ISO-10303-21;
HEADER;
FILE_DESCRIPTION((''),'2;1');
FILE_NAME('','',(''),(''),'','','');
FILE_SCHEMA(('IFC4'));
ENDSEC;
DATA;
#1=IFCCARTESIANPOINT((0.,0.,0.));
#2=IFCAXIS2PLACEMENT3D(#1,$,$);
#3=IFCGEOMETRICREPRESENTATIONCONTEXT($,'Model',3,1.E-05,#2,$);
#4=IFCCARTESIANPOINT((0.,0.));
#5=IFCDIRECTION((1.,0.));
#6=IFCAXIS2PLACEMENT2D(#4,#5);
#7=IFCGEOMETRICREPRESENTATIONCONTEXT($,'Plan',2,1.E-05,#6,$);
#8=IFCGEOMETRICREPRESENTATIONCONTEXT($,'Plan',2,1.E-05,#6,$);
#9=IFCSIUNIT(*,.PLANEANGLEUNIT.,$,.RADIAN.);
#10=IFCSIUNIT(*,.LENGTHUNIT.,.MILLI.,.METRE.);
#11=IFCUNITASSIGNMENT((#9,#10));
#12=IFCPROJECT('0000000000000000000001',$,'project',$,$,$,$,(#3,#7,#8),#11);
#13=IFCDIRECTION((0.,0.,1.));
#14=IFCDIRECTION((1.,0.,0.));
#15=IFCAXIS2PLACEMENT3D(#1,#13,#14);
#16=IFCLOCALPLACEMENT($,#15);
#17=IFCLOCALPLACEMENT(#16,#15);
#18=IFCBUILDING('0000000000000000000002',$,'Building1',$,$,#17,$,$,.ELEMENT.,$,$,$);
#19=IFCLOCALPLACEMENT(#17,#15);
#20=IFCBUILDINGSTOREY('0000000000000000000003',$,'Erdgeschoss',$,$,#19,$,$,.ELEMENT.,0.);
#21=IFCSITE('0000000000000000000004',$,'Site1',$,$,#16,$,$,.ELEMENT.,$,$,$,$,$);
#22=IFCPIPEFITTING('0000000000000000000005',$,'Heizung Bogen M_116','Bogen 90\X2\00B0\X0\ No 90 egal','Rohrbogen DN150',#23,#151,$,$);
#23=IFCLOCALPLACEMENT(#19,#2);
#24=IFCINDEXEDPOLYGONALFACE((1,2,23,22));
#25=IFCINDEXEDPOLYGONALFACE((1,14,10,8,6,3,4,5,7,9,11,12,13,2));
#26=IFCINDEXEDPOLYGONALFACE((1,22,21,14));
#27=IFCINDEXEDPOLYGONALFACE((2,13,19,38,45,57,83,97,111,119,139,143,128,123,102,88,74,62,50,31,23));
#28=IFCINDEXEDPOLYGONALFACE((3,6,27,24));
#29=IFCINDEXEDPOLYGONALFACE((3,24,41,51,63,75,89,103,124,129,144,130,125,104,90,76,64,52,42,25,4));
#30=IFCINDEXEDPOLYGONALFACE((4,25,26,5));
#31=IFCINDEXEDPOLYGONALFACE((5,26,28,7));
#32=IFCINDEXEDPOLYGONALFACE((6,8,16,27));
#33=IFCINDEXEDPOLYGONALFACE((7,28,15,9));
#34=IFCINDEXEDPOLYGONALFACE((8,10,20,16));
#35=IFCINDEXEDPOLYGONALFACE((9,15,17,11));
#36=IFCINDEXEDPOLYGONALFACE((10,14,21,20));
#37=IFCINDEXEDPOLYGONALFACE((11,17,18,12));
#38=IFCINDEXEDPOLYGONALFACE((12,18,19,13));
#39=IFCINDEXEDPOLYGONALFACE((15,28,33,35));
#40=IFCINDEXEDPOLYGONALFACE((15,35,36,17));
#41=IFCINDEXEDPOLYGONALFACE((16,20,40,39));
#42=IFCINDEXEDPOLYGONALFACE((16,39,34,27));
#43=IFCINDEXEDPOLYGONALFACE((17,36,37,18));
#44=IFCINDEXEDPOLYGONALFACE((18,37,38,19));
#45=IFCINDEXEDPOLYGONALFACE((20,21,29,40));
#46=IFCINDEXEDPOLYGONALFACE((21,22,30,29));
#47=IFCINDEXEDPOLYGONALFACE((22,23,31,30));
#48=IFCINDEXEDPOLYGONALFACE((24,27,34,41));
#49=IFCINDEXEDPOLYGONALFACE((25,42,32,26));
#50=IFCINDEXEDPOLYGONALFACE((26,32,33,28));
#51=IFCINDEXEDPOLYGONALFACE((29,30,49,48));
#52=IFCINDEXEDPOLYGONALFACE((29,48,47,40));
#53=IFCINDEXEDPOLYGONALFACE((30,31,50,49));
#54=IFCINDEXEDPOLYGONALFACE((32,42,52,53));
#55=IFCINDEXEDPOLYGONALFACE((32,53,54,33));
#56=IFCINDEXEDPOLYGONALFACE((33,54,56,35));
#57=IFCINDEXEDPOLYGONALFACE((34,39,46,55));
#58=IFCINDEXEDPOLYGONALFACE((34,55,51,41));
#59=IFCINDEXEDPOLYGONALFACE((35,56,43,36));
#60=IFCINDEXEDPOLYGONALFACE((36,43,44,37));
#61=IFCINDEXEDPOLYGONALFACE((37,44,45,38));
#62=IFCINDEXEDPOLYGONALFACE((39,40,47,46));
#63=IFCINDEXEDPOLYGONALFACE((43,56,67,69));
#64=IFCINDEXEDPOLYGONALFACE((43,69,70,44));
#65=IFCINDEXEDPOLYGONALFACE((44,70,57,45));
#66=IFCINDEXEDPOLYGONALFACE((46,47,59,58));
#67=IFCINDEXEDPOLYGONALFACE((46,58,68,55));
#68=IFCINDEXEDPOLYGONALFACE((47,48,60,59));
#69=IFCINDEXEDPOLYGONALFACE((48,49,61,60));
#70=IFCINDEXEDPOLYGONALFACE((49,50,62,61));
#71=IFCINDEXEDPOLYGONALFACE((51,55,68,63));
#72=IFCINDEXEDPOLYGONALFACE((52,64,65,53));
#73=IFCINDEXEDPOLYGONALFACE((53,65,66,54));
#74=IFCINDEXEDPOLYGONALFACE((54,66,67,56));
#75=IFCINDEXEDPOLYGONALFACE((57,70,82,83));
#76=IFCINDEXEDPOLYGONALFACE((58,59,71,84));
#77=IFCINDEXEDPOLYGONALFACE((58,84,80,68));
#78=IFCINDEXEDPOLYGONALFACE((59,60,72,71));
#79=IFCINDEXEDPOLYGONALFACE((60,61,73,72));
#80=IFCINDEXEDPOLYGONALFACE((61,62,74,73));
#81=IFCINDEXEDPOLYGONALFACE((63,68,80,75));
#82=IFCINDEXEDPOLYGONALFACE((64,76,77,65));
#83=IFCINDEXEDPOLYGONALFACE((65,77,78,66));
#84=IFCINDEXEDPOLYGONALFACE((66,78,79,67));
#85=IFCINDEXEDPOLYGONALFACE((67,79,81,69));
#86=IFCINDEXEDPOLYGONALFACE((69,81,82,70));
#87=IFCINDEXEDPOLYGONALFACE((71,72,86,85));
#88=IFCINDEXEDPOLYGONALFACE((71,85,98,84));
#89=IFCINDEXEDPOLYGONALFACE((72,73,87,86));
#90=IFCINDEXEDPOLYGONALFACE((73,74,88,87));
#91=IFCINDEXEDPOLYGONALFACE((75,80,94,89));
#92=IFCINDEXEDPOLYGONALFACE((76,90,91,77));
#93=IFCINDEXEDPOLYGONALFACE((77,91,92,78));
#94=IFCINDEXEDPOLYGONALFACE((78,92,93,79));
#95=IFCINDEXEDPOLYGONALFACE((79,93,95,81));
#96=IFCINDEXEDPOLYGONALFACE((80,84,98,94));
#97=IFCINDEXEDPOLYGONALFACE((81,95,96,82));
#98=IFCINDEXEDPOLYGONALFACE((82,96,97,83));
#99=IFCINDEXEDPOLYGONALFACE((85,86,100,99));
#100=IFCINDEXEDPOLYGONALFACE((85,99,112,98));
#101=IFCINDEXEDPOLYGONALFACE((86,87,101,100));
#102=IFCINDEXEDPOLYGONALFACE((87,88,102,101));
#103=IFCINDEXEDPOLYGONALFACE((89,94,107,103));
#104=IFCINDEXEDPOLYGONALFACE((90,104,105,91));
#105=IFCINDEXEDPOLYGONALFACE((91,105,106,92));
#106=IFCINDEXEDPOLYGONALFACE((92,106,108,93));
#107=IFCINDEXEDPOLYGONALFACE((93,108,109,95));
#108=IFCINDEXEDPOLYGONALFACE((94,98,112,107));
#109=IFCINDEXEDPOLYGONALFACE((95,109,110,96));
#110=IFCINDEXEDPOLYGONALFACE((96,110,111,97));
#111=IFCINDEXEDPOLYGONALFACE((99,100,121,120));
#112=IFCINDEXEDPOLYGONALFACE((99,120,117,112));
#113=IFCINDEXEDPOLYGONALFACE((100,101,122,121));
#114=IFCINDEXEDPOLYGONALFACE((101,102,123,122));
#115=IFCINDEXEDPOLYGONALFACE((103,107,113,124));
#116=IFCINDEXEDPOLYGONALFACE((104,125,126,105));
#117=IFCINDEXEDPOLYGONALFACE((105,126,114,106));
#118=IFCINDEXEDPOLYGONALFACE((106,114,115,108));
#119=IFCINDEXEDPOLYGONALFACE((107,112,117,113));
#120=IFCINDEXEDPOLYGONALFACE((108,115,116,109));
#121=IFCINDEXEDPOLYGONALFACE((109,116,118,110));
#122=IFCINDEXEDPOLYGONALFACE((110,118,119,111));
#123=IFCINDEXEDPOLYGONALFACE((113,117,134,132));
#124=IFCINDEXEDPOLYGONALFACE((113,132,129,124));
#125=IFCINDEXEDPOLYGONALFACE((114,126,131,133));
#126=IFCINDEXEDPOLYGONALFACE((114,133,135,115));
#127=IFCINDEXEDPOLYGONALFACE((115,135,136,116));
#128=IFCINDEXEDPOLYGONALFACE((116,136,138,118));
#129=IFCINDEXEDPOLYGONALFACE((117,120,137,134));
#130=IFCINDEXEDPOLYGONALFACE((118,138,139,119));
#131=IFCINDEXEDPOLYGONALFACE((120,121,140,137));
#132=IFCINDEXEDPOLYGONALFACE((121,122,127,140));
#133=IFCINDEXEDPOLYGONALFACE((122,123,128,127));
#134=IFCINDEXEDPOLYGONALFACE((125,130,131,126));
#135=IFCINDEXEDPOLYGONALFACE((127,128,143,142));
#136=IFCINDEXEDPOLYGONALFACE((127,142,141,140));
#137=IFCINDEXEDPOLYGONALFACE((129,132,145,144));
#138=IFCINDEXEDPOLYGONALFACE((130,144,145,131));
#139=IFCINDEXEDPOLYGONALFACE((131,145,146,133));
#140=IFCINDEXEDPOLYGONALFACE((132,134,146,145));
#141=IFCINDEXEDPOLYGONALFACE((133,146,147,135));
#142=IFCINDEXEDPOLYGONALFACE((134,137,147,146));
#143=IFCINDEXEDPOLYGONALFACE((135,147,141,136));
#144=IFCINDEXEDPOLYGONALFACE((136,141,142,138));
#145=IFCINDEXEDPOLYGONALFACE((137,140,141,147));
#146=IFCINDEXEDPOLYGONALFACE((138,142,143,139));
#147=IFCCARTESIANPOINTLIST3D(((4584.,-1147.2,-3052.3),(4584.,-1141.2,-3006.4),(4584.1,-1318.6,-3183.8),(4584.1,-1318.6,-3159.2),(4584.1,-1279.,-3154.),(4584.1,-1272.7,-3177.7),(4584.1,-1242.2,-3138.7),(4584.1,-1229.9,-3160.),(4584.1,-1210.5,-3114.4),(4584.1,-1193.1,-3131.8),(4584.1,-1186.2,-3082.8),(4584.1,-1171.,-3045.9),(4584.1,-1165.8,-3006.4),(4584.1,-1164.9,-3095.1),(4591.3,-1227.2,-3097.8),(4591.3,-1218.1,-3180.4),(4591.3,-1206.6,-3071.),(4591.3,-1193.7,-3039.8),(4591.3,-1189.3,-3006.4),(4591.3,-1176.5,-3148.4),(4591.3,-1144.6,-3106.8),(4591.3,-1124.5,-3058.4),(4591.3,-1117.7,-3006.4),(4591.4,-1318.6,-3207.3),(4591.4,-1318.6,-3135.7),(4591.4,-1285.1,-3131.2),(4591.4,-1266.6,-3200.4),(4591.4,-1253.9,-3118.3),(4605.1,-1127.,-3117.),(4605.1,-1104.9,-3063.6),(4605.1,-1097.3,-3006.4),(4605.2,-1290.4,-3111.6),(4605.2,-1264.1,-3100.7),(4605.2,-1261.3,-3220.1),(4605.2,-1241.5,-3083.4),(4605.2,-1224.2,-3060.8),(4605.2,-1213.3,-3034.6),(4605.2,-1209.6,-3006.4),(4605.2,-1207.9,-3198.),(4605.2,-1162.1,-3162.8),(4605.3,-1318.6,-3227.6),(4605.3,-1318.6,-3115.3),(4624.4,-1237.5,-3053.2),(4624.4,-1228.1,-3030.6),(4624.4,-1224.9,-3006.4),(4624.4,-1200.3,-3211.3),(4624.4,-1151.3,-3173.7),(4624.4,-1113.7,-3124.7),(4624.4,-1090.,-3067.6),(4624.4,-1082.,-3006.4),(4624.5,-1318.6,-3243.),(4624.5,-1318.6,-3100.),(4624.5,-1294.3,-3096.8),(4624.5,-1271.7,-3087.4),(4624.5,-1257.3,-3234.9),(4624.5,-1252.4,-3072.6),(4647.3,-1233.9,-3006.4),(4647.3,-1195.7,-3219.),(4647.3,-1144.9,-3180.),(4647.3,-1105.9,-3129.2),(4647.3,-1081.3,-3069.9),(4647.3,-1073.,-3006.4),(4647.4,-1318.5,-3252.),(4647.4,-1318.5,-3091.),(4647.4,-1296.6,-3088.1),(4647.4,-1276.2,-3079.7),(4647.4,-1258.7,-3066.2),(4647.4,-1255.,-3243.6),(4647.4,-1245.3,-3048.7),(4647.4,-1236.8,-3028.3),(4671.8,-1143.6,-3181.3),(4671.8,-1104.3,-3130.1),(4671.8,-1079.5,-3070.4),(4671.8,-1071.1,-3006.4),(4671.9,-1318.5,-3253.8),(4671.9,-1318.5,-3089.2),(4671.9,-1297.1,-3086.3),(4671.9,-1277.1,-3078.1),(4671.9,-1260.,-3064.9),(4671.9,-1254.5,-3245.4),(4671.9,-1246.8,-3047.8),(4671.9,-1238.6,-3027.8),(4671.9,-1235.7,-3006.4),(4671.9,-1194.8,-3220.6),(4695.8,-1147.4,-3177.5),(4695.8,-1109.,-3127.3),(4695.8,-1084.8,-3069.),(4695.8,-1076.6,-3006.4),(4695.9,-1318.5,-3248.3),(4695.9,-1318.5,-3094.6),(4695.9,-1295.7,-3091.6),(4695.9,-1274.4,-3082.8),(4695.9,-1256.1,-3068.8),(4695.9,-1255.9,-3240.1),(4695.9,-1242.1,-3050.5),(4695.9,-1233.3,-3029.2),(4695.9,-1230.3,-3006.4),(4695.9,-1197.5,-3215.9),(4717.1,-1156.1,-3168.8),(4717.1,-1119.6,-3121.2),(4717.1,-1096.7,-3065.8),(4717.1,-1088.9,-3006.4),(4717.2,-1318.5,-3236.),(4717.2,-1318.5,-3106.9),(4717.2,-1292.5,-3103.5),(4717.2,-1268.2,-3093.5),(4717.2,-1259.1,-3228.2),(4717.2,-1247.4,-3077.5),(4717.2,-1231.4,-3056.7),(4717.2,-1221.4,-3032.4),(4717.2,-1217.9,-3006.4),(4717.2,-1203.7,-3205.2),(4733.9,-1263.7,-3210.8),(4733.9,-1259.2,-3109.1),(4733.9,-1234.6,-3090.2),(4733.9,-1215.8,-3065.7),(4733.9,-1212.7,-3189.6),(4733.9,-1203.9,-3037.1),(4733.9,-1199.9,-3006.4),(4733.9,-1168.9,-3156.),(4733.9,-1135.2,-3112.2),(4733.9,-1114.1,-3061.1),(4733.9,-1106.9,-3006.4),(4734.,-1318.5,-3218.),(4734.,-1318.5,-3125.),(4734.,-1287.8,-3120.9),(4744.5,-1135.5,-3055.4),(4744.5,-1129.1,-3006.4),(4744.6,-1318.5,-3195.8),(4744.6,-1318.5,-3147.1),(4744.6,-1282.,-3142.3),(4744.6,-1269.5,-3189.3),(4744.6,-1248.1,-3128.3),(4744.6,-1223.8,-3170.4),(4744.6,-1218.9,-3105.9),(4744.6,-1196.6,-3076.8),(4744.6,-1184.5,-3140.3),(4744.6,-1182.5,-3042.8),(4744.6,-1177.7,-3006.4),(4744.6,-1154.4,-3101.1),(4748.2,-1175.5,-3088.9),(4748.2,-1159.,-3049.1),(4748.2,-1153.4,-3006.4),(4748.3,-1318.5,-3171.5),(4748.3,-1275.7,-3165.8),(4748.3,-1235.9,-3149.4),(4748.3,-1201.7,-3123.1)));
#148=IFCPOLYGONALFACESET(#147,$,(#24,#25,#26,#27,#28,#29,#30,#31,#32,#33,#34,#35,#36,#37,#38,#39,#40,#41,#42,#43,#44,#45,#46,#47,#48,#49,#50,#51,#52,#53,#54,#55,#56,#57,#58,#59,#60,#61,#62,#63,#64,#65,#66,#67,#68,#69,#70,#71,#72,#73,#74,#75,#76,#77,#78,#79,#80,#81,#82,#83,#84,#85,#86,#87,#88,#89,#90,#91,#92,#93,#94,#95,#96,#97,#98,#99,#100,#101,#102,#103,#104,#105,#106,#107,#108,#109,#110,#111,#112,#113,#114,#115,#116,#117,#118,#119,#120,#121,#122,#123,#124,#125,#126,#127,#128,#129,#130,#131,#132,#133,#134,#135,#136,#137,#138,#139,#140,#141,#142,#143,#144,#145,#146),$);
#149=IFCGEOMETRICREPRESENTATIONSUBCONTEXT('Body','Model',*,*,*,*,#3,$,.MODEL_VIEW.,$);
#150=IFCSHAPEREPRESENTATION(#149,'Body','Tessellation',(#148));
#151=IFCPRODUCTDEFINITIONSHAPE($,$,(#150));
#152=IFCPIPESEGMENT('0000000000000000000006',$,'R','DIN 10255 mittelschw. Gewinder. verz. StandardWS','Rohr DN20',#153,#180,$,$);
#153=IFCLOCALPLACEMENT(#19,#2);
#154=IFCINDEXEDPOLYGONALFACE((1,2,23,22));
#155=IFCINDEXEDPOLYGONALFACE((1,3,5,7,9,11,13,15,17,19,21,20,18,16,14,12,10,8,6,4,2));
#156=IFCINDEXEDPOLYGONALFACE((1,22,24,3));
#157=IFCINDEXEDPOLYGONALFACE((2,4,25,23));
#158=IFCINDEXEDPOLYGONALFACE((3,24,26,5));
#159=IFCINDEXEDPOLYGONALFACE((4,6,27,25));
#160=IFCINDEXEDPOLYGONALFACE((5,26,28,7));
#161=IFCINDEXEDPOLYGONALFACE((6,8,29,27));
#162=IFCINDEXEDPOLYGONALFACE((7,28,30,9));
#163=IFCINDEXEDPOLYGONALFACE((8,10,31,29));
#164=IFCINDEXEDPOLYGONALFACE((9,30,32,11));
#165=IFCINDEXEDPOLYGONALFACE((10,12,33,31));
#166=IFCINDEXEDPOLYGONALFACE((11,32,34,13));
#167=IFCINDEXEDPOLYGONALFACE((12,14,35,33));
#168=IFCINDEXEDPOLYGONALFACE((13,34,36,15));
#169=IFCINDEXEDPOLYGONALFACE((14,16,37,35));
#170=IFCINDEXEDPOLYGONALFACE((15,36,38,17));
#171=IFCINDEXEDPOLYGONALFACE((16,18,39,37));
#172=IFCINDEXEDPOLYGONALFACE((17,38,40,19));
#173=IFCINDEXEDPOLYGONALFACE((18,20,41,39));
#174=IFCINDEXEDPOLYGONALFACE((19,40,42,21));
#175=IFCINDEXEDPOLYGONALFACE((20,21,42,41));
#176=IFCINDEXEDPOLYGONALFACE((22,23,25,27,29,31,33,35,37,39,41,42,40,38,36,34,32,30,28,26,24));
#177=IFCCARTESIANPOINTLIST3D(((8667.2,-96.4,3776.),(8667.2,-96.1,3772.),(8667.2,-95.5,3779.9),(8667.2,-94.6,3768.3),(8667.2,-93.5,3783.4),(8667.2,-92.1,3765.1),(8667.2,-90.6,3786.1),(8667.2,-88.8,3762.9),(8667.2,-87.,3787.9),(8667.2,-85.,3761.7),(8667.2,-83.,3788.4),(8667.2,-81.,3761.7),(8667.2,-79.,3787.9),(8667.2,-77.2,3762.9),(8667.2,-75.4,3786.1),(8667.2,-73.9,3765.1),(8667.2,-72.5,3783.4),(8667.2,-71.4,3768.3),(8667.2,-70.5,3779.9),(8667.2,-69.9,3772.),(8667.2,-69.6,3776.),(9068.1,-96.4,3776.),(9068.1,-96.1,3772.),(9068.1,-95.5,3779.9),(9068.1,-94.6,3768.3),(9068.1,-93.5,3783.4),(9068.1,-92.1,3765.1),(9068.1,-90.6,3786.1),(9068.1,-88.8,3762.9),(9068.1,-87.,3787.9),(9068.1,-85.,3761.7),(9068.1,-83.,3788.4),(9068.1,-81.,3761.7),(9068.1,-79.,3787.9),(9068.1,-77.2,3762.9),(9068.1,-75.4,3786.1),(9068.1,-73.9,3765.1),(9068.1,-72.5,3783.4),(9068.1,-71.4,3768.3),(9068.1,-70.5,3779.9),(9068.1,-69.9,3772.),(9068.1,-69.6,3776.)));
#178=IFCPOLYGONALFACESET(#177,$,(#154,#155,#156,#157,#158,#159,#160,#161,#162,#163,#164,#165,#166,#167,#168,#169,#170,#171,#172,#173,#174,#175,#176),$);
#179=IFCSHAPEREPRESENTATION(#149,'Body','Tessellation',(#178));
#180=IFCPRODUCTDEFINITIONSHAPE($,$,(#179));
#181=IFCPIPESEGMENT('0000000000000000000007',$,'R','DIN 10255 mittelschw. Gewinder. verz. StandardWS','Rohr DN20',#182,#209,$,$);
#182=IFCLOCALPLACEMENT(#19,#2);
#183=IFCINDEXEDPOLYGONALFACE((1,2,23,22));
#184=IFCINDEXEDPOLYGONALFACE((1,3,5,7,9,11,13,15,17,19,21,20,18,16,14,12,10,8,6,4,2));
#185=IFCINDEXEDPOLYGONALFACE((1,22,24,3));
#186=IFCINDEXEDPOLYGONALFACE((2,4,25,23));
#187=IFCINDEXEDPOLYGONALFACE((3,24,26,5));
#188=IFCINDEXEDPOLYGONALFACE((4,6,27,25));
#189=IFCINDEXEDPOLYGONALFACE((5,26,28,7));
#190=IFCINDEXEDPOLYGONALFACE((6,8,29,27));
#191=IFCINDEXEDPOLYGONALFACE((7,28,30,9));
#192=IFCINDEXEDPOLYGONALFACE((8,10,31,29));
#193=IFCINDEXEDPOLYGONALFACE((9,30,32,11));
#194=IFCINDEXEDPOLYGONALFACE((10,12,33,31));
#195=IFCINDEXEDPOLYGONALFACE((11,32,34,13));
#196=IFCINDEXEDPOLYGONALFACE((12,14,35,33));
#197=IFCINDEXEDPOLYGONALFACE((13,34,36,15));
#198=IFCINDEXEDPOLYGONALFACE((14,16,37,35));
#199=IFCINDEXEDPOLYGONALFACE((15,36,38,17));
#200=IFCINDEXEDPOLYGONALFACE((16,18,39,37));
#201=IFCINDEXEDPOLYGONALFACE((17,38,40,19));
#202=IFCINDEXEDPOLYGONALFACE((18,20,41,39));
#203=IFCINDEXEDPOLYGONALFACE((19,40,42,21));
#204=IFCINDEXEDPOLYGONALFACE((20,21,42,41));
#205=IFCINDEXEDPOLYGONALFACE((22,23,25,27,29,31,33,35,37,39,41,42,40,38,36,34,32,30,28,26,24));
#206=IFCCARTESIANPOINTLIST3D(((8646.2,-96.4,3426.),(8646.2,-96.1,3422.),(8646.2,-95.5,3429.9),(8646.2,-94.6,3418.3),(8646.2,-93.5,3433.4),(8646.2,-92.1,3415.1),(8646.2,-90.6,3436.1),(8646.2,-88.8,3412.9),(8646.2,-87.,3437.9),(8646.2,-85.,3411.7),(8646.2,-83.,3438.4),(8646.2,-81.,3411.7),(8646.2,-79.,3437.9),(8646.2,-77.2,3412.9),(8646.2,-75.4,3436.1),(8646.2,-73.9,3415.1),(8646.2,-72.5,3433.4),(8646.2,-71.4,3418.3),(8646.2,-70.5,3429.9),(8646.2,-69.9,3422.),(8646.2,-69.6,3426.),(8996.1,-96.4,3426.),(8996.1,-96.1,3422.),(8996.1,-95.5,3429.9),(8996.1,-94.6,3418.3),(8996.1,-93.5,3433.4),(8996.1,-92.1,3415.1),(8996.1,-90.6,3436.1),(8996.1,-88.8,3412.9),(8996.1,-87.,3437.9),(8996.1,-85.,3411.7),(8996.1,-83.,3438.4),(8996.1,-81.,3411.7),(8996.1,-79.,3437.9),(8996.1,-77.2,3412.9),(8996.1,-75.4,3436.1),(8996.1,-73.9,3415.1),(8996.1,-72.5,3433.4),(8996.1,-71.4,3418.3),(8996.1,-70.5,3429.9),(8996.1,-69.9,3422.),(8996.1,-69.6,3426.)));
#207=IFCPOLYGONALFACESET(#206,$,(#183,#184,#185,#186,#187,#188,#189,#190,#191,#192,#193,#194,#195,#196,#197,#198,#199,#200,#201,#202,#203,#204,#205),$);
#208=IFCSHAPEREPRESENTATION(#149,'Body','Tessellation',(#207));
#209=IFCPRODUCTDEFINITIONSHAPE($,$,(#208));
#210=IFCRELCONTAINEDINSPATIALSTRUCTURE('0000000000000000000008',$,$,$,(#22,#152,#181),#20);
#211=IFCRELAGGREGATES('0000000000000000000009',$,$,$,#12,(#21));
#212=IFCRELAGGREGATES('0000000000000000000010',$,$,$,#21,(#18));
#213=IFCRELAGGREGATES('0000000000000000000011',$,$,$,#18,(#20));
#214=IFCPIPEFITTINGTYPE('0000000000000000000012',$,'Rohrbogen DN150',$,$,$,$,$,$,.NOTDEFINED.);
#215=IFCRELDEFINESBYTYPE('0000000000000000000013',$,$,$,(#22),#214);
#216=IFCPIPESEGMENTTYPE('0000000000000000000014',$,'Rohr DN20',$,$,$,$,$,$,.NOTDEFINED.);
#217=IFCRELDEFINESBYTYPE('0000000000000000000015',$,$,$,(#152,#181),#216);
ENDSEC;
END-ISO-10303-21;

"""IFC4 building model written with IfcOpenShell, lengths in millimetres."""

from ifc_helpers import new_model, entity, si_unit, frame, origin, origin_with_axes, origin_2d_with_axis, place, context, subcontext, project, spatial, circle, extrude, source, transform, mapped, type_object, element, save


model = new_model("IFC4")

# Units and contexts
model_context = context("Model", 3, precision=1e-05, world=origin())
plan_context_1 = context("Plan", 2, precision=1e-05, world=origin_2d_with_axis())
plan_context_2 = context("Plan", 2, precision=1e-05, world=origin_2d_with_axis())
body_context = subcontext(model_context, "Body", "Model", "MODEL_VIEW")
ifc_project = project(units=[si_unit("PLANEANGLEUNIT", "RADIAN"), si_unit("LENGTHUNIT", "METRE", prefix="MILLI")], contexts=[model_context, plan_context_1, plan_context_2])

# Site, building, storey
site_placement = place(None, origin_with_axes())
site = spatial("IfcSite", under=ifc_project, at=site_placement, Name="Site1", CompositionType="ELEMENT")
building_placement = place(site_placement, origin_with_axes())
building = spatial("IfcBuilding", under=site, at=building_placement, Name="Building1", CompositionType="ELEMENT")
storey_placement = place(building_placement, origin_with_axes())
storey = spatial("IfcBuildingStorey", under=building, at=storey_placement, Name="Erdgeschoss", CompositionType="ELEMENT", Elevation=0.0)

# Pipe fitting
pipe_fitting_type_1 = type_object("IfcPipeFittingType", Name="Rohrbogen DN150", PredefinedType="NOTDEFINED")
shared_shape_1 = source(origin_with_axes(), body_context, "Body", "SolidModel", [
    entity("IfcRevolvedAreaSolid", entity("IfcCircleProfileDef", "AREA", None, entity("IfcAxis2Placement2D", entity("IfcCartesianPoint", [0.0, 0.0]), entity("IfcDirection", [1.0, 0.0])), 82.5), entity("IfcAxis2Placement3D", entity("IfcCartesianPoint", [123.8, 0.0, 41.3]), entity("IfcDirection", [-1.0, 0.0, 0.0]), entity("IfcDirection", [0.0, 1.0, 0.000562])), entity("IfcAxis1Placement", entity("IfcCartesianPoint", [0.0, 165.1, 0.0]), entity("IfcDirection", [-1.0, 0.0, 0.0])), 1.570796),
])
pipe_fitting_1_placement = place(storey_placement, frame((4665.7, -1194.7, -3130.2), z_axis=(0.0, 0.0, 1.0), x_axis=(1.0, 0.0, 0.0)))
element("IfcPipeFitting", 1, at=pipe_fitting_1_placement, inside=storey, type_object=pipe_fitting_type_1, Name="Heizung Bogen M_116", Description="Bogen 90° No 90 egal", ObjectType="Rohrbogen DN150", context=body_context, shape_type="MappedRepresentation", body=[
    mapped(shared_shape_1, transform((0.0, 0.0, 0.0), x_axis=(0.0, 0.0, 1.0), y_axis=(1.0, 0.0, 0.0), z_axis=(0.0, 1.0, 0.0), scale=1.0)),
])

# Pipe segments
pipe_segment_type_1 = type_object("IfcPipeSegmentType", Name="Rohr DN20", PredefinedType="NOTDEFINED")
pipe_segment_1_placement = place(storey_placement, frame((8867.7, -83.2, 3775.0), z_axis=(0.0, 0.0, 1.0), x_axis=(1.0, 0.0, 0.0)))
element("IfcPipeSegment", 2, at=pipe_segment_1_placement, inside=storey, type_object=pipe_segment_type_1, Name="R", Description="DIN 10255 mittelschw. Gewinder. verz. StandardWS", ObjectType="Rohr DN20", context=body_context, shape_type="SolidModel", body=[
    extrude(circle(Radius=13.4, at=origin_2d_with_axis()), frame((200.5, 0.1, 0.0), z_axis=(-1.0, 0.0, 0.0), x_axis=(0.0, 0.0, 1.0)), (0.0, 0.0, 1.0), 400.9),
])
pipe_segment_2_placement = place(storey_placement, frame((8821.2, -83.2, 3425.0), z_axis=(0.0, 0.0, 1.0), x_axis=(1.0, 0.0, 0.0)))
element("IfcPipeSegment", 3, at=pipe_segment_2_placement, inside=storey, type_object=pipe_segment_type_1, Name="R", Description="DIN 10255 mittelschw. Gewinder. verz. StandardWS", ObjectType="Rohr DN20", context=body_context, shape_type="SolidModel", body=[
    extrude(circle(Radius=13.4, at=origin_2d_with_axis()), frame((175.0, 0.2, 0.0), z_axis=(-1.0, 0.0, 0.0), x_axis=(0.0, 0.0, 1.0)), (0.0, 0.0, 1.0), 349.9),
])

save(model, "model.ifc")
